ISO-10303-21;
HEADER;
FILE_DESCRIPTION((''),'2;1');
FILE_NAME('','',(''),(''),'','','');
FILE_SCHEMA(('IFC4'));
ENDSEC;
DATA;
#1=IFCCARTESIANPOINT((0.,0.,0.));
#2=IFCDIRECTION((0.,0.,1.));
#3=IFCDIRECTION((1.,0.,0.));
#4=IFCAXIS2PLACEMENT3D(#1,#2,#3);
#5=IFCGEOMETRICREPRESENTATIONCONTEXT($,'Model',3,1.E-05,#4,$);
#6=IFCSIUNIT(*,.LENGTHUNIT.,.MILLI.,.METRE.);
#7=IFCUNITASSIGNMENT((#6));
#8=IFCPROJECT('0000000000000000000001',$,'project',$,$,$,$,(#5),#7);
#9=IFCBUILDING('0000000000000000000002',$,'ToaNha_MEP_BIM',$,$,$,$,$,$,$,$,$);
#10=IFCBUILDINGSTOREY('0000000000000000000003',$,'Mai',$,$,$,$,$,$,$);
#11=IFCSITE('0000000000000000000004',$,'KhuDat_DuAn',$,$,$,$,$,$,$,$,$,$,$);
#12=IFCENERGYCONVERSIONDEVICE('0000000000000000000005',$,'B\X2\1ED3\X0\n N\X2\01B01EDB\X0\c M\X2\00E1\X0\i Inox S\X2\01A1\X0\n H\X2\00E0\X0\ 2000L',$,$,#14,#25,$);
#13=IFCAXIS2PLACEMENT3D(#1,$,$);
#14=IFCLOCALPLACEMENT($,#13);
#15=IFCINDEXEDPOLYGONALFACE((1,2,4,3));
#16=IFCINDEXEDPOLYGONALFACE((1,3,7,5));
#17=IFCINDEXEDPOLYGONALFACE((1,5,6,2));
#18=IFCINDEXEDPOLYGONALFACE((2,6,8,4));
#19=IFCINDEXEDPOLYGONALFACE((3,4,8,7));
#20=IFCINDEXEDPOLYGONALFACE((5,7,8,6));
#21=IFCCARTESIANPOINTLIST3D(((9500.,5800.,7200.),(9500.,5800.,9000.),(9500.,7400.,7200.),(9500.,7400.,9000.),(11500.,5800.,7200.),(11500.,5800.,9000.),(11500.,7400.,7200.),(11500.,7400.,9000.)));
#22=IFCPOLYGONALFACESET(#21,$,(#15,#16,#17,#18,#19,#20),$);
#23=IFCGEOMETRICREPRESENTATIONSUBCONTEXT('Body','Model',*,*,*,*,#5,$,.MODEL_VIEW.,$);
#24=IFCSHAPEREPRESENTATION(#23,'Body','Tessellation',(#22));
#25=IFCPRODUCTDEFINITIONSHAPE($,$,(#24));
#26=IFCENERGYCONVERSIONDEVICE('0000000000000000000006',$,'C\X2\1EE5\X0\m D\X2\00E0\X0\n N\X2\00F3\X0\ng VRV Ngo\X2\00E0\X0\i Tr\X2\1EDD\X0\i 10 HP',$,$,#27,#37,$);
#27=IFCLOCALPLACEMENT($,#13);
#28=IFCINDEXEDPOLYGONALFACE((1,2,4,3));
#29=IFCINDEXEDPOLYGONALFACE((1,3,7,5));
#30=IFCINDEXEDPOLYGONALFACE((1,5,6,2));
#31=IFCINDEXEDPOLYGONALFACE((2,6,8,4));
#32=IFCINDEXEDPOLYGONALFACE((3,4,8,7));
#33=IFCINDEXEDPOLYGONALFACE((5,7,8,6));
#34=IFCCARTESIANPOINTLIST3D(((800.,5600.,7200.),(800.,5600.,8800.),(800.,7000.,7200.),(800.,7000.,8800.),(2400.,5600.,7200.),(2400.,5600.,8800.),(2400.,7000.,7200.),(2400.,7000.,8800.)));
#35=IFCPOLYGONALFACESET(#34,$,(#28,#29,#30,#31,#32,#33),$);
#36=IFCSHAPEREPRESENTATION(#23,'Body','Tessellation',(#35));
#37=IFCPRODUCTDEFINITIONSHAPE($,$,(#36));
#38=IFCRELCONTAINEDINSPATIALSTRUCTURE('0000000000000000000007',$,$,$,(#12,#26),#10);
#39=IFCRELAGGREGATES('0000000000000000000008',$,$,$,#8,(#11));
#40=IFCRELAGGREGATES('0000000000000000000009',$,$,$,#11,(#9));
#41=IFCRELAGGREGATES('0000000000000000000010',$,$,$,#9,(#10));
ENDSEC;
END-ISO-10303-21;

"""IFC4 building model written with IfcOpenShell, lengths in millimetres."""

from ifc_helpers import new_model, si_unit, frame, origin_with_axes, context, subcontext, project, spatial, polyline, outline, extrude, element, save


model = new_model("IFC4")

# Units and contexts
model_context = context("Model", 3, precision=1e-05, world=origin_with_axes())
body_context = subcontext(model_context, "Body", "Model", "MODEL_VIEW")
ifc_project = project(units=[si_unit("LENGTHUNIT", "METRE", prefix="MILLI")], contexts=[model_context])

# Site, building, storey
site = spatial("IfcSite", under=ifc_project, Name="KhuDat_DuAn")
building = spatial("IfcBuilding", under=site, Name="ToaNha_MEP_BIM")
storey = spatial("IfcBuildingStorey", under=building, Name="Mai")

# Energy conversion devices
element("IfcEnergyConversionDevice", 1, inside=storey, Name="Bồn Nước Mái Inox Sơn Hà 2000L", context=body_context, shape_type="SweptSolid", body=[
    extrude(outline(polyline([(9500.0, 5800.0), (11500.0, 5800.0), (11500.0, 7400.0), (9500.0, 7400.0), (9500.0, 5800.0)])), frame((0.0, 0.0, 7200.0), z_axis=(0.0, 0.0, 1.0), x_axis=(1.0, 0.0, 0.0)), (0.0, 0.0, 1.0), 1800.0),
])
element("IfcEnergyConversionDevice", 2, inside=storey, Name="Cụm Dàn Nóng VRV Ngoài Trời 10 HP", context=body_context, shape_type="SweptSolid", body=[
    extrude(outline(polyline([(800.0, 5600.0), (2400.0, 5600.0), (2400.0, 7000.0), (800.0, 7000.0), (800.0, 5600.0)])), frame((0.0, 0.0, 7200.0), z_axis=(0.0, 0.0, 1.0), x_axis=(1.0, 0.0, 0.0)), (0.0, 0.0, 1.0), 1600.0),
])

save(model, "model.ifc")
